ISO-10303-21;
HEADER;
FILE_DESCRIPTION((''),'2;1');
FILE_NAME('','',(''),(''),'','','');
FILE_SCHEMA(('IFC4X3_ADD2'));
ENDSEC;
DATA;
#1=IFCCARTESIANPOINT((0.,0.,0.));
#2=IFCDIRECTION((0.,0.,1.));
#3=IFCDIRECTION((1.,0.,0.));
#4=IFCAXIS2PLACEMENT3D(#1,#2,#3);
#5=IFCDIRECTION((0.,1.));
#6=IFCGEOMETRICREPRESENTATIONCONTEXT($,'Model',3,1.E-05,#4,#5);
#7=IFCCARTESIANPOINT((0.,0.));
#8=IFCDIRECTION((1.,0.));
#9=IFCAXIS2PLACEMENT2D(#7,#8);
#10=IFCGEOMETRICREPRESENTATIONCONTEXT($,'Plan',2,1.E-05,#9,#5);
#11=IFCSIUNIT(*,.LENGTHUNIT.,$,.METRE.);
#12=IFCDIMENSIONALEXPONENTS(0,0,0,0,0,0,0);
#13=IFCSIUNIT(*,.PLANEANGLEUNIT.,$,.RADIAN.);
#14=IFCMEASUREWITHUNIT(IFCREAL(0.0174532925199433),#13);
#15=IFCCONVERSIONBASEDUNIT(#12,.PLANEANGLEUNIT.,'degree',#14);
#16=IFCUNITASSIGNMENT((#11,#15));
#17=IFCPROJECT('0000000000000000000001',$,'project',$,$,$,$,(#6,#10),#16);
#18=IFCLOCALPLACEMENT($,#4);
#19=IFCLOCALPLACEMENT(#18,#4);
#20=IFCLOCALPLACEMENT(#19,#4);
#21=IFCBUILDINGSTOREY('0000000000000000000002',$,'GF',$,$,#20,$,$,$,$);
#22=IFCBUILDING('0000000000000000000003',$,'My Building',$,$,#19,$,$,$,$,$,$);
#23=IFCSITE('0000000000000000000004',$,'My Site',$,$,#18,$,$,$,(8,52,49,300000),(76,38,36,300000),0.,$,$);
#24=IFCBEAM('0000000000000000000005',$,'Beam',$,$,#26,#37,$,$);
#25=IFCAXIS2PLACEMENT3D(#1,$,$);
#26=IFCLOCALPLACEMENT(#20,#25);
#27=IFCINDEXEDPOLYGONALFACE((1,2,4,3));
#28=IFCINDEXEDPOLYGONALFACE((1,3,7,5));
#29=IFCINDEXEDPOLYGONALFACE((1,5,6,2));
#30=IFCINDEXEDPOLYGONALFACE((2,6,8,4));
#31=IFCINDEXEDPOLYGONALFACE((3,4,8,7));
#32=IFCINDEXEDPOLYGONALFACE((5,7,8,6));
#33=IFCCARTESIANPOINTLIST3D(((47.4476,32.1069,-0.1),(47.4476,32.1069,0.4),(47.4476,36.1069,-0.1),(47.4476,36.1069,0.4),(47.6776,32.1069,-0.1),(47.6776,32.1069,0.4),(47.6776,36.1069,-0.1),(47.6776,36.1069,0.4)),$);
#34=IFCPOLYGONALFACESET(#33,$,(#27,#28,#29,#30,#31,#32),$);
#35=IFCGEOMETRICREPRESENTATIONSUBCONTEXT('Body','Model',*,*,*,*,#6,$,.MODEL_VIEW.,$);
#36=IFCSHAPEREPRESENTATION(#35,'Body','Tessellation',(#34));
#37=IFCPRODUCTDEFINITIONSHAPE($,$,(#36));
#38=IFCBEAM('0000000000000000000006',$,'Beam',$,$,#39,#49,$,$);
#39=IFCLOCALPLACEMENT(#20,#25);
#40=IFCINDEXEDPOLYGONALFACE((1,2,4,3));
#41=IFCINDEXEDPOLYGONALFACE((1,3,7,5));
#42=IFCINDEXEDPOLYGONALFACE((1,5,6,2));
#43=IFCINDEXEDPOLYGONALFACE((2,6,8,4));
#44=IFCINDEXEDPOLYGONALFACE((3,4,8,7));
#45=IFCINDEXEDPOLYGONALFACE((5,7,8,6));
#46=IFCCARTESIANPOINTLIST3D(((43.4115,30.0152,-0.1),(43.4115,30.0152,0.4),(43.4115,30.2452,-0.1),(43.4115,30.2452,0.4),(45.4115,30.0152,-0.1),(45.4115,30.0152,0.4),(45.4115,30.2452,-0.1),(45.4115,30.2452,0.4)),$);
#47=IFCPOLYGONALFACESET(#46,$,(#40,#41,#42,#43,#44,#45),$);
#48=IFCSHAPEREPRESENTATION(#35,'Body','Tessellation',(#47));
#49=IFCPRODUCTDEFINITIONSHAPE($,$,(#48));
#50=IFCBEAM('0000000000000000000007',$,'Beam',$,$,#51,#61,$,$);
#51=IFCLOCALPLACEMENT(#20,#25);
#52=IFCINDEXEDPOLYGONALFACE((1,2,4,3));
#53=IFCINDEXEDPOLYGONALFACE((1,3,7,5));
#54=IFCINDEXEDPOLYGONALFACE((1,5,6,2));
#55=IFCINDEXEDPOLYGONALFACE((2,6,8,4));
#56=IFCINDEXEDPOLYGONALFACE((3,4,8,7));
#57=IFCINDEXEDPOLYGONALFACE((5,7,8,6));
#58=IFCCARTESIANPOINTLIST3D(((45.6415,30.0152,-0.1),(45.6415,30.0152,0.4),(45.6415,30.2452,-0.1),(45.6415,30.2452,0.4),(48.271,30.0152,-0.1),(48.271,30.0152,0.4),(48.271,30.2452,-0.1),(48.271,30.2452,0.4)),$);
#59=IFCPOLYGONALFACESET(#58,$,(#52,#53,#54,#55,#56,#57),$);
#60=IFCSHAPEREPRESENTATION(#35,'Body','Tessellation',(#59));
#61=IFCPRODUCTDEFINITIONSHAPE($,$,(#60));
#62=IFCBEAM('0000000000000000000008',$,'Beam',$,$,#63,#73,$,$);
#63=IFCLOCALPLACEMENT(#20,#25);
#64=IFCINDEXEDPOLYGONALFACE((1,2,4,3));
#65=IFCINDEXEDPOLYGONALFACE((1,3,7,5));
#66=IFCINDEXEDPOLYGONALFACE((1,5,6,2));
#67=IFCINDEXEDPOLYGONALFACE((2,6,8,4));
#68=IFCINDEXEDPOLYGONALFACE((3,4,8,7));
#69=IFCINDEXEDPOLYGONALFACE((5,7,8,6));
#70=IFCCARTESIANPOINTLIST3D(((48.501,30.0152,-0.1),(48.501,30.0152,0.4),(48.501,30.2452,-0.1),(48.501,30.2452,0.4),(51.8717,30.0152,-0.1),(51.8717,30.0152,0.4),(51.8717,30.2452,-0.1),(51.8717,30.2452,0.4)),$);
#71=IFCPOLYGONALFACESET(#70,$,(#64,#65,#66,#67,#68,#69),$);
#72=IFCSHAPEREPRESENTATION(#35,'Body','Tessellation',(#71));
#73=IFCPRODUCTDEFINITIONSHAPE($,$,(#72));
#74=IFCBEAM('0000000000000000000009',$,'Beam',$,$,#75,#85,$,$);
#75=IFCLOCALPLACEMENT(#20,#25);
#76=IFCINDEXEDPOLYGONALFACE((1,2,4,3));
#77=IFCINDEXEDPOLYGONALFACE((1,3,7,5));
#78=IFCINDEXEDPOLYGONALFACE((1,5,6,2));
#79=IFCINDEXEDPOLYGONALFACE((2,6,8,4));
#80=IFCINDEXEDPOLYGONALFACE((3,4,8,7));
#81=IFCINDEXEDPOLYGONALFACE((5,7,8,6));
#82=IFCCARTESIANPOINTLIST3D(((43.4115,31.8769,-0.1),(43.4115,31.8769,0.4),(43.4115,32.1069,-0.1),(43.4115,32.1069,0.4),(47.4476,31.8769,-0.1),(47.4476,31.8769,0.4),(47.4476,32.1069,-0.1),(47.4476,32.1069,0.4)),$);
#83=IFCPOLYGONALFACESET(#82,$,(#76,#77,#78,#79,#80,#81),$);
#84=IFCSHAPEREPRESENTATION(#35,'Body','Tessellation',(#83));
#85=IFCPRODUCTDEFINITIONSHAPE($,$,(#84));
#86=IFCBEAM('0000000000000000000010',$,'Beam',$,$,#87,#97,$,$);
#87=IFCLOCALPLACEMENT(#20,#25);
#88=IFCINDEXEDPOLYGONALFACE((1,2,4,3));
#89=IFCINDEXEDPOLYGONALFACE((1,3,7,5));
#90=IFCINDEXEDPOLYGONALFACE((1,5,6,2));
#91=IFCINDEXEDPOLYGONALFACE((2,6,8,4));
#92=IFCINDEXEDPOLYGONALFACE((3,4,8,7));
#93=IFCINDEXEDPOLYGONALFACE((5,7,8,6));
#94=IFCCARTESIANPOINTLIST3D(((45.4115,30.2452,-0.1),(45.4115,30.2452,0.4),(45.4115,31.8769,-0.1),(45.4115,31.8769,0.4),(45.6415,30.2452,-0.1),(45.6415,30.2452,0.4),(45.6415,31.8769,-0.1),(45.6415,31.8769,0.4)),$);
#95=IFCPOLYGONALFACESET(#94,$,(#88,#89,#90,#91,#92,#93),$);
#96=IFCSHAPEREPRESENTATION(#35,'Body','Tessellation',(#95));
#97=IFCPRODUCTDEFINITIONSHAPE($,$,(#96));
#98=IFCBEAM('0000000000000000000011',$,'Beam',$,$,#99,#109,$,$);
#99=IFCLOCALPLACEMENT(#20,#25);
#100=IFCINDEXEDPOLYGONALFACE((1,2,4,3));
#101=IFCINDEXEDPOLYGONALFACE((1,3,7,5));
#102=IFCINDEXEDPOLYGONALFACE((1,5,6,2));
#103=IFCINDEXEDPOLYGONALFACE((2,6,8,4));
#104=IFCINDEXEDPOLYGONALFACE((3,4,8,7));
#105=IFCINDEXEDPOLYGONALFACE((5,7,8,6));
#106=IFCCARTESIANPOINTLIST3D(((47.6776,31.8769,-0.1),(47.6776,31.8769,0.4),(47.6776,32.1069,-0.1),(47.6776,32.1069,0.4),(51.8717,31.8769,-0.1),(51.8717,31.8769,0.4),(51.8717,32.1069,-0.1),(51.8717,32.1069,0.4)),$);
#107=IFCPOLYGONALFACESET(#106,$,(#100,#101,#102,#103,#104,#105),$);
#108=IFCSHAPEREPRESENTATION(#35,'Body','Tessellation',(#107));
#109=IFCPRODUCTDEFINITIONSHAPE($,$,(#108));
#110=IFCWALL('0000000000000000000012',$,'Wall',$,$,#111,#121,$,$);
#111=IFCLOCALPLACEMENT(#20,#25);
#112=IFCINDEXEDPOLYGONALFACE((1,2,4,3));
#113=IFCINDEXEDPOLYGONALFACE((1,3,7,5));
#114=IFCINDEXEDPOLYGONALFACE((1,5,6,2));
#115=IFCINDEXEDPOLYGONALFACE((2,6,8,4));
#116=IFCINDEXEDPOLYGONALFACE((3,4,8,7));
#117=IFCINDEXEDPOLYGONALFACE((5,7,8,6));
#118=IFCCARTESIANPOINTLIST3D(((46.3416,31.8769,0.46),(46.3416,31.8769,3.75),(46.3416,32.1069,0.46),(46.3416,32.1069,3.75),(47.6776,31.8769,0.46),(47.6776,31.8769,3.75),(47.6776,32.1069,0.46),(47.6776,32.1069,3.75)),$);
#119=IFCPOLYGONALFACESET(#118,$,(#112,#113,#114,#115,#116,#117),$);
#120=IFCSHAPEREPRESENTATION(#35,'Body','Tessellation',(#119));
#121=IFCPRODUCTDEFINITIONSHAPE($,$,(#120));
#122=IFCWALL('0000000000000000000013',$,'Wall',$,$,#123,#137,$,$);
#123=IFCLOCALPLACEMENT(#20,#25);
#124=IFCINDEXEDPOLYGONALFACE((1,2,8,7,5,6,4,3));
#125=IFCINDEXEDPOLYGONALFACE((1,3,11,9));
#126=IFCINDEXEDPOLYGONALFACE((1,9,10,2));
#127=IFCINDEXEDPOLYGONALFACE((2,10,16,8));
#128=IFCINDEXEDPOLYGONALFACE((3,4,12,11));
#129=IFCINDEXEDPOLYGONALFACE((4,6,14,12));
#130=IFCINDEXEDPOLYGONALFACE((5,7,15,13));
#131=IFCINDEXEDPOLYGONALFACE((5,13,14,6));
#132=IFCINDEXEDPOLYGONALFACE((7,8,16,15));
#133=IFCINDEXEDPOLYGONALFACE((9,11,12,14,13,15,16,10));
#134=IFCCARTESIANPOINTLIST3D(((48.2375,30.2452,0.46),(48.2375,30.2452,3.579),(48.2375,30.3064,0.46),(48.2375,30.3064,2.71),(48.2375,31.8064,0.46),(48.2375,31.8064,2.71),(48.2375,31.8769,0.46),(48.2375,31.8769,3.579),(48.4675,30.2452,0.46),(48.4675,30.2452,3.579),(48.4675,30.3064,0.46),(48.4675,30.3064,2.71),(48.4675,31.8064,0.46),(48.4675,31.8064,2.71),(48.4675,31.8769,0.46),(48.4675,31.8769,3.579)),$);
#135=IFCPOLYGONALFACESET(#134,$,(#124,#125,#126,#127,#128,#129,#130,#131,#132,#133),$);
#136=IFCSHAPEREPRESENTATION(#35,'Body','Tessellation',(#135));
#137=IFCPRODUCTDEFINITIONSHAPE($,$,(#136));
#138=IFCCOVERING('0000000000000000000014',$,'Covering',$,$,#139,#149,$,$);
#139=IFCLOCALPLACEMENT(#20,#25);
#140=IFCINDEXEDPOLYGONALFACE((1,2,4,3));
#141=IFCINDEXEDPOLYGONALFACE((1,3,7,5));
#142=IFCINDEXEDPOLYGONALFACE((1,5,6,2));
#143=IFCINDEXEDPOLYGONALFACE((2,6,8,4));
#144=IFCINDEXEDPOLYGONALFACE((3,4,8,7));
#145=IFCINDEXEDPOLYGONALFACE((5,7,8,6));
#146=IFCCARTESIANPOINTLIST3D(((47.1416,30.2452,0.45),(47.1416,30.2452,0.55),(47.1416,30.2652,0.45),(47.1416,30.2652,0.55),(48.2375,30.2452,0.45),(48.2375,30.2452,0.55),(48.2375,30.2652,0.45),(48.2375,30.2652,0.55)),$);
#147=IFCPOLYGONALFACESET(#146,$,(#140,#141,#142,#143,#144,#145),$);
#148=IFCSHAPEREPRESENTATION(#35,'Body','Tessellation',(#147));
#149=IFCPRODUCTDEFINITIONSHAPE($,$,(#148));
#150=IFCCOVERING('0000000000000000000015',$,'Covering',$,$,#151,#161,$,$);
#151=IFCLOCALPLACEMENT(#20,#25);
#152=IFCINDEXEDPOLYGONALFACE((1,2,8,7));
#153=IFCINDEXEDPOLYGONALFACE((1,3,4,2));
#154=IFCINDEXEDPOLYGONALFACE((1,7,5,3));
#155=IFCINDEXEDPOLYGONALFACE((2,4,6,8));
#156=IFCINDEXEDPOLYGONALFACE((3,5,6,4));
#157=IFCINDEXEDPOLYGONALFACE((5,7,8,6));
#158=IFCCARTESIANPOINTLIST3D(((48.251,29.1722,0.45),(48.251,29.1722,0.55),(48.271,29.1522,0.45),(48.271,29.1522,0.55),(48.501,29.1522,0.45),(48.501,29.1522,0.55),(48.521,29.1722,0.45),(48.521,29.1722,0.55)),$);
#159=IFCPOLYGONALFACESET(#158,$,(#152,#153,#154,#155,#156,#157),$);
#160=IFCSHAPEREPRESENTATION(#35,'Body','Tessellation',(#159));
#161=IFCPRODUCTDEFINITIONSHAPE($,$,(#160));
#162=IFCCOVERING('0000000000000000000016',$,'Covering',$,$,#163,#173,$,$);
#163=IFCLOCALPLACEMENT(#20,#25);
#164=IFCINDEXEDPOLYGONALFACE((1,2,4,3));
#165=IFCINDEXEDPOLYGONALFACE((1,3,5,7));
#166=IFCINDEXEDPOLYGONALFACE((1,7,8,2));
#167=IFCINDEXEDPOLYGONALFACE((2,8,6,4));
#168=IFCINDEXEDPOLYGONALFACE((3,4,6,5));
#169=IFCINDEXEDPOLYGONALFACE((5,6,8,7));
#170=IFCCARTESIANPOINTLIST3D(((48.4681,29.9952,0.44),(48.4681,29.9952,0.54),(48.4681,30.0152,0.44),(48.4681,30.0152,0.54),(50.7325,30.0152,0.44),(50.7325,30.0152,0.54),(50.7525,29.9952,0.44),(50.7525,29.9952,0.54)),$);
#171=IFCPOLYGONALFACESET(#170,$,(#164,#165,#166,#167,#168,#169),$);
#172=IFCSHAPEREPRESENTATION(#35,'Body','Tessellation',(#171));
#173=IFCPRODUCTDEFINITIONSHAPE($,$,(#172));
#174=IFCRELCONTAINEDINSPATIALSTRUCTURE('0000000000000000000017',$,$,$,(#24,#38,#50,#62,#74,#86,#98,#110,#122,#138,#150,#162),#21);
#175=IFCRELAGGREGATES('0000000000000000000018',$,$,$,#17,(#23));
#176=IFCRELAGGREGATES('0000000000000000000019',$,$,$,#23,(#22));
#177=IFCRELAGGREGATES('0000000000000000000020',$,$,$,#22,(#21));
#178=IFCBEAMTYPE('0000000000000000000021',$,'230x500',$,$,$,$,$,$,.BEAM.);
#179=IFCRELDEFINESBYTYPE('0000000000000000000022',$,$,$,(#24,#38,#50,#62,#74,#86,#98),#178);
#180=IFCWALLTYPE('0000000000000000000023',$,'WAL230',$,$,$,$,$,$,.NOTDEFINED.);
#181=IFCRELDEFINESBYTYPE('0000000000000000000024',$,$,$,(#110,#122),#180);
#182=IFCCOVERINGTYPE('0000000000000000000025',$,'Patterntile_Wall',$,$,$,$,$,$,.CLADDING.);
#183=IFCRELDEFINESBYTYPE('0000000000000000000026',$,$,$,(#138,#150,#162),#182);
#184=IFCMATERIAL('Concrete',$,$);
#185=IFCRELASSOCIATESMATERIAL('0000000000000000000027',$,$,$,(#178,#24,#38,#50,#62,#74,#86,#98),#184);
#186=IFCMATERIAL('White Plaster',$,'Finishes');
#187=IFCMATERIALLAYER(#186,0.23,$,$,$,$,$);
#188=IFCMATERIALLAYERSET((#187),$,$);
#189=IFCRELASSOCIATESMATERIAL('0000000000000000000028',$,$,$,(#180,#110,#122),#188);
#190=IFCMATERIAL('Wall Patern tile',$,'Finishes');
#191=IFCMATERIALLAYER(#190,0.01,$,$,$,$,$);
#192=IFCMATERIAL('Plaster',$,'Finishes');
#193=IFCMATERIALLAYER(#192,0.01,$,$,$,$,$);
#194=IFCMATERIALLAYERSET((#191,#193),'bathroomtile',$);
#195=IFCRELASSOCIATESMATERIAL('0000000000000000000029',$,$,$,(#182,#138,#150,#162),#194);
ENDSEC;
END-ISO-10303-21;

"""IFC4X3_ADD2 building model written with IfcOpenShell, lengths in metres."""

from ifc_helpers import new_model, entity, si_unit, converted_unit, direction, frame, origin_with_axes, origin_2d_with_axis, place, context, subcontext, project, spatial, line, indexed_curve, rectangle, outline, extrude, source, transform, mapped, material, layer, layer_set, layer_usage, material_profile, profile_set, profile_usage, type_object, element, save


model = new_model("IFC4X3_ADD2")

# Units and contexts
model_context = context("Model", 3, precision=1e-05, world=origin_with_axes(), true_north=direction((0.0, 1.0)))
plan_context = context("Plan", 2, precision=1e-05, world=origin_2d_with_axis(), true_north=direction((0.0, 1.0)))
body_context_1 = subcontext(model_context, "Body", "Model", "MODEL_VIEW")
ifc_project = project(units=[si_unit("LENGTHUNIT", "METRE"), converted_unit("PLANEANGLEUNIT", "degree", entity("IfcReal", 0.0174532925199433), si_unit("PLANEANGLEUNIT", "RADIAN"), dimensions=[0, 0, 0, 0, 0, 0, 0])], contexts=[model_context, plan_context])

# Site, building, storey
site_placement = place(None, origin_with_axes())
site = spatial("IfcSite", under=ifc_project, at=site_placement, Name="My Site", RefLatitude=(8, 52, 49, 300000), RefLongitude=(76, 38, 36, 300000), RefElevation=0.0)
building_placement = place(site_placement, origin_with_axes())
building = spatial("IfcBuilding", under=site, at=building_placement, Name="My Building")
storey_placement = place(building_placement, origin_with_axes())
storey = spatial("IfcBuildingStorey", under=building, at=storey_placement, Name="GF")

# Beams
ifc_material_1 = material(Name="Concrete")
ifc_material_profile = material_profile(ifc_material_1, rectangle(XDim=0.23, YDim=0.5))
ifc_profile_set = profile_set([ifc_material_profile])
ifc_profile_usage_1 = profile_usage(ifc_profile_set, cardinal=5)
beam_type = type_object("IfcBeamType", Name="230x500", PredefinedType="BEAM", material=ifc_profile_set)
beam_1_placement = place(storey_placement, frame((47.5626, 32.1069, 0.15), z_axis=(0.0, 1.0, 0.0), x_axis=(-1.0, 0.0, 0.0)))
element("IfcBeam", 1, at=beam_1_placement, inside=storey, type_object=beam_type, material=ifc_profile_usage_1, Name="Beam", context=body_context_1, shape_type="SweptSolid", body=[
    extrude(rectangle(XDim=0.23, YDim=0.5), origin_with_axes(), (0.0, 0.0, 1.0), 4.0),
])
ifc_profile_usage_2 = profile_usage(ifc_profile_set, cardinal=5)
beam_2_placement = place(storey_placement, frame((43.4115, 30.1302, 0.15), z_axis=(1.0, 0.0, 0.0), x_axis=(0.0, 1.0, 0.0)))
element("IfcBeam", 2, at=beam_2_placement, inside=storey, type_object=beam_type, material=ifc_profile_usage_2, Name="Beam", context=body_context_1, shape_type="SweptSolid", body=[
    extrude(rectangle(XDim=0.23, YDim=0.5), origin_with_axes(), (0.0, 0.0, 1.0), 2.0),
])
ifc_profile_usage_3 = profile_usage(ifc_profile_set, cardinal=5)
beam_3_placement = place(storey_placement, frame((45.6415, 30.1302, 0.15), z_axis=(1.0, 0.0, 0.0), x_axis=(0.0, 1.0, 0.0)))
element("IfcBeam", 3, at=beam_3_placement, inside=storey, type_object=beam_type, material=ifc_profile_usage_3, Name="Beam", context=body_context_1, shape_type="SweptSolid", body=[
    extrude(rectangle(XDim=0.23, YDim=0.5), origin_with_axes(), (0.0, 0.0, 1.0), 2.6295),
])
ifc_profile_usage_4 = profile_usage(ifc_profile_set, cardinal=5)
beam_4_placement = place(storey_placement, frame((48.501, 30.1302, 0.15), z_axis=(1.0, 0.0, 0.0), x_axis=(0.0, 1.0, 0.0)))
element("IfcBeam", 4, at=beam_4_placement, inside=storey, type_object=beam_type, material=ifc_profile_usage_4, Name="Beam", context=body_context_1, shape_type="SweptSolid", body=[
    extrude(rectangle(XDim=0.23, YDim=0.5), origin_with_axes(), (0.0, 0.0, 1.0), 3.3707),
])
ifc_profile_usage_5 = profile_usage(ifc_profile_set, cardinal=5)
beam_5_placement = place(storey_placement, frame((43.4115, 31.9919, 0.15), z_axis=(1.0, 0.0, 0.0), x_axis=(0.0, 1.0, 0.0)))
element("IfcBeam", 5, at=beam_5_placement, inside=storey, type_object=beam_type, material=ifc_profile_usage_5, Name="Beam", context=body_context_1, shape_type="SweptSolid", body=[
    extrude(rectangle(XDim=0.23, YDim=0.5), origin_with_axes(), (0.0, 0.0, 1.0), 4.0361),
])
ifc_profile_usage_6 = profile_usage(ifc_profile_set, cardinal=5)
beam_6_placement = place(storey_placement, frame((45.5265, 30.2452, 0.15), z_axis=(0.0, 1.0, 0.0), x_axis=(-1.0, 0.0, 0.0)))
element("IfcBeam", 6, at=beam_6_placement, inside=storey, type_object=beam_type, material=ifc_profile_usage_6, Name="Beam", context=body_context_1, shape_type="SweptSolid", body=[
    extrude(rectangle(XDim=0.23, YDim=0.5), origin_with_axes(), (0.0, 0.0, 1.0), 1.6317),
])
ifc_profile_usage_7 = profile_usage(ifc_profile_set, cardinal=5)
beam_7_placement = place(storey_placement, frame((47.6776, 31.9919, 0.15), z_axis=(1.0, 0.0, 0.0), x_axis=(0.0, 1.0, 0.0)))
element("IfcBeam", 7, at=beam_7_placement, inside=storey, type_object=beam_type, material=ifc_profile_usage_7, Name="Beam", context=body_context_1, shape_type="SweptSolid", body=[
    extrude(rectangle(XDim=0.23, YDim=0.5), origin_with_axes(), (0.0, 0.0, 1.0), 4.1941),
])

# Shared definitions
ifc_material_2 = material(Name="White Plaster", Category="Finishes")
ifc_layer_1 = layer(ifc_material_2, 0.23)
ifc_layer_set_1 = layer_set([ifc_layer_1])
wall_type = type_object("IfcWallType", Name="WAL230", PredefinedType="NOTDEFINED", material=ifc_layer_set_1)

# Wall
ifc_layer_usage_1 = layer_usage(ifc_layer_set_1, "AXIS2", "NEGATIVE", 0.0)
wall_1_placement = place(storey_placement, frame((47.6776, 31.8769, 0.46), z_axis=(0.0, 0.0, 1.0), x_axis=(-1.0, 0.0, 0.0)))
element("IfcWall", 8, at=wall_1_placement, inside=storey, type_object=wall_type, material=ifc_layer_usage_1, Name="Wall", context=body_context_1, shape_type="SweptSolid", body=[
    extrude(outline(indexed_curve([(0.0, -0.23), (0.0, 0.0), (1.336, 0.0), (1.336, -0.23)], segments=[line(1, 2, 3, 4, 1)])), origin_with_axes(), (0.0, 0.0, 1.0), 3.29),
])

# Wall, opening
ifc_layer_usage_2 = layer_usage(ifc_layer_set_1, "AXIS2", "POSITIVE", 0.0)
wall_2_placement = place(storey_placement, frame((48.4675, 30.2452, 0.46), z_axis=(0.0, 0.0, 1.0), x_axis=(0.0, 1.0, 0.0)))
wall_2 = element("IfcWall", 9, at=wall_2_placement, inside=storey, type_object=wall_type, material=ifc_layer_usage_2, Name="Wall", context=body_context_1, shape_type="SweptSolid", body=[
    extrude(outline(indexed_curve([(0.0, 0.0), (0.0, 0.23), (1.6317, 0.23), (1.6317, 0.0)], segments=[line(1, 2, 3, 4, 1)])), origin_with_axes(), (0.0, 0.0, 1.0), 3.119),
])
shared_shape_1 = source(origin_with_axes(), body_context_1, "Body", "SweptSolid", [
    extrude(outline(indexed_curve([(0.0, 0.0), (1.5, 0.0), (1.5, 2.25), (0.0, 2.25)], segments=[line(1, 2, 3, 4, 1)])), frame((0.0, -0.6, 0.0), z_axis=(0.0, -1.0, 0.0), x_axis=(1.0, 0.0, 0.0)), (0.0, 0.0, -1.0), 1.2),
])
opening_1_placement = place(wall_2_placement, frame((0.0612, 0.0, 0.0), z_axis=(0.0, 0.0, 1.0), x_axis=(1.0, 0.0, 0.0)))
element("IfcOpeningElement", 10, at=opening_1_placement, cuts=wall_2, PredefinedType="OPENING", context=body_context_1, shape_type="MappedRepresentation", body=[
    mapped(shared_shape_1, transform((0.0, 0.0, 0.0), x_axis=(1.0, 0.0, 0.0), y_axis=(0.0, 1.0, 0.0), z_axis=(0.0, 0.0, 1.0), scale=1.0)),
])

# Coverings
ifc_material_3 = material(Name="Wall Patern tile", Category="Finishes")
ifc_layer_2 = layer(ifc_material_3, 0.01)
ifc_material_4 = material(Name="Plaster", Category="Finishes")
ifc_layer_3 = layer(ifc_material_4, 0.01)
ifc_layer_set_2 = layer_set([ifc_layer_2, ifc_layer_3], Name="bathroomtile")
ifc_layer_usage_3 = layer_usage(ifc_layer_set_2, "AXIS2", "NEGATIVE", 0.0)
covering_type = type_object("IfcCoveringType", Name="Patterntile_Wall", PredefinedType="CLADDING", material=ifc_layer_set_2)
covering_1_placement = place(storey_placement, frame((47.1416, 30.2652, 0.45), z_axis=(0.0, 0.0, 1.0), x_axis=(1.0, -0.000001, 0.0)))
element("IfcCovering", 11, at=covering_1_placement, inside=storey, type_object=covering_type, material=ifc_layer_usage_3, Name="Covering", context=body_context_1, shape_type="SweptSolid", body=[
    extrude(outline(indexed_curve([(0.0, -0.02), (0.0, 0.0), (1.0959, 0.0), (1.0959, -0.02)], segments=[line(1, 2, 3, 4, 1)])), origin_with_axes(), (0.0, 0.0, 1.0), 0.1),
])
ifc_layer_usage_4 = layer_usage(ifc_layer_set_2, "AXIS2", "NEGATIVE", 0.0)
covering_2_placement = place(storey_placement, frame((48.251, 29.1722, 0.45), z_axis=(0.0, 0.0, 1.0), x_axis=(1.0, -0.000001, 0.0)))
element("IfcCovering", 12, at=covering_2_placement, inside=storey, type_object=covering_type, material=ifc_layer_usage_4, Name="Covering", context=body_context_1, shape_type="SweptSolid", body=[
    extrude(outline(indexed_curve([(0.02, -0.02), (0.0, 0.0), (0.27, 0.0), (0.25, -0.02)], segments=[line(1, 2, 3, 4, 1)])), origin_with_axes(), (0.0, 0.0, 1.0), 0.1),
])
ifc_layer_usage_5 = layer_usage(ifc_layer_set_2, "AXIS2", "POSITIVE", 0.0)
covering_3_placement = place(storey_placement, frame((48.4681, 29.9952, 0.44), z_axis=(0.0, 0.0, 1.0), x_axis=(1.0, -0.000001, 0.0)))
element("IfcCovering", 13, at=covering_3_placement, inside=storey, type_object=covering_type, material=ifc_layer_usage_5, Name="Covering", context=body_context_1, shape_type="SweptSolid", body=[
    extrude(outline(indexed_curve([(0.0, 0.0), (0.0, 0.02), (2.2644, 0.02), (2.2844, 0.0)], segments=[line(1, 2, 3, 4, 1)])), origin_with_axes(), (0.0, 0.0, 1.0), 0.1),
])

save(model, "model.ifc")
